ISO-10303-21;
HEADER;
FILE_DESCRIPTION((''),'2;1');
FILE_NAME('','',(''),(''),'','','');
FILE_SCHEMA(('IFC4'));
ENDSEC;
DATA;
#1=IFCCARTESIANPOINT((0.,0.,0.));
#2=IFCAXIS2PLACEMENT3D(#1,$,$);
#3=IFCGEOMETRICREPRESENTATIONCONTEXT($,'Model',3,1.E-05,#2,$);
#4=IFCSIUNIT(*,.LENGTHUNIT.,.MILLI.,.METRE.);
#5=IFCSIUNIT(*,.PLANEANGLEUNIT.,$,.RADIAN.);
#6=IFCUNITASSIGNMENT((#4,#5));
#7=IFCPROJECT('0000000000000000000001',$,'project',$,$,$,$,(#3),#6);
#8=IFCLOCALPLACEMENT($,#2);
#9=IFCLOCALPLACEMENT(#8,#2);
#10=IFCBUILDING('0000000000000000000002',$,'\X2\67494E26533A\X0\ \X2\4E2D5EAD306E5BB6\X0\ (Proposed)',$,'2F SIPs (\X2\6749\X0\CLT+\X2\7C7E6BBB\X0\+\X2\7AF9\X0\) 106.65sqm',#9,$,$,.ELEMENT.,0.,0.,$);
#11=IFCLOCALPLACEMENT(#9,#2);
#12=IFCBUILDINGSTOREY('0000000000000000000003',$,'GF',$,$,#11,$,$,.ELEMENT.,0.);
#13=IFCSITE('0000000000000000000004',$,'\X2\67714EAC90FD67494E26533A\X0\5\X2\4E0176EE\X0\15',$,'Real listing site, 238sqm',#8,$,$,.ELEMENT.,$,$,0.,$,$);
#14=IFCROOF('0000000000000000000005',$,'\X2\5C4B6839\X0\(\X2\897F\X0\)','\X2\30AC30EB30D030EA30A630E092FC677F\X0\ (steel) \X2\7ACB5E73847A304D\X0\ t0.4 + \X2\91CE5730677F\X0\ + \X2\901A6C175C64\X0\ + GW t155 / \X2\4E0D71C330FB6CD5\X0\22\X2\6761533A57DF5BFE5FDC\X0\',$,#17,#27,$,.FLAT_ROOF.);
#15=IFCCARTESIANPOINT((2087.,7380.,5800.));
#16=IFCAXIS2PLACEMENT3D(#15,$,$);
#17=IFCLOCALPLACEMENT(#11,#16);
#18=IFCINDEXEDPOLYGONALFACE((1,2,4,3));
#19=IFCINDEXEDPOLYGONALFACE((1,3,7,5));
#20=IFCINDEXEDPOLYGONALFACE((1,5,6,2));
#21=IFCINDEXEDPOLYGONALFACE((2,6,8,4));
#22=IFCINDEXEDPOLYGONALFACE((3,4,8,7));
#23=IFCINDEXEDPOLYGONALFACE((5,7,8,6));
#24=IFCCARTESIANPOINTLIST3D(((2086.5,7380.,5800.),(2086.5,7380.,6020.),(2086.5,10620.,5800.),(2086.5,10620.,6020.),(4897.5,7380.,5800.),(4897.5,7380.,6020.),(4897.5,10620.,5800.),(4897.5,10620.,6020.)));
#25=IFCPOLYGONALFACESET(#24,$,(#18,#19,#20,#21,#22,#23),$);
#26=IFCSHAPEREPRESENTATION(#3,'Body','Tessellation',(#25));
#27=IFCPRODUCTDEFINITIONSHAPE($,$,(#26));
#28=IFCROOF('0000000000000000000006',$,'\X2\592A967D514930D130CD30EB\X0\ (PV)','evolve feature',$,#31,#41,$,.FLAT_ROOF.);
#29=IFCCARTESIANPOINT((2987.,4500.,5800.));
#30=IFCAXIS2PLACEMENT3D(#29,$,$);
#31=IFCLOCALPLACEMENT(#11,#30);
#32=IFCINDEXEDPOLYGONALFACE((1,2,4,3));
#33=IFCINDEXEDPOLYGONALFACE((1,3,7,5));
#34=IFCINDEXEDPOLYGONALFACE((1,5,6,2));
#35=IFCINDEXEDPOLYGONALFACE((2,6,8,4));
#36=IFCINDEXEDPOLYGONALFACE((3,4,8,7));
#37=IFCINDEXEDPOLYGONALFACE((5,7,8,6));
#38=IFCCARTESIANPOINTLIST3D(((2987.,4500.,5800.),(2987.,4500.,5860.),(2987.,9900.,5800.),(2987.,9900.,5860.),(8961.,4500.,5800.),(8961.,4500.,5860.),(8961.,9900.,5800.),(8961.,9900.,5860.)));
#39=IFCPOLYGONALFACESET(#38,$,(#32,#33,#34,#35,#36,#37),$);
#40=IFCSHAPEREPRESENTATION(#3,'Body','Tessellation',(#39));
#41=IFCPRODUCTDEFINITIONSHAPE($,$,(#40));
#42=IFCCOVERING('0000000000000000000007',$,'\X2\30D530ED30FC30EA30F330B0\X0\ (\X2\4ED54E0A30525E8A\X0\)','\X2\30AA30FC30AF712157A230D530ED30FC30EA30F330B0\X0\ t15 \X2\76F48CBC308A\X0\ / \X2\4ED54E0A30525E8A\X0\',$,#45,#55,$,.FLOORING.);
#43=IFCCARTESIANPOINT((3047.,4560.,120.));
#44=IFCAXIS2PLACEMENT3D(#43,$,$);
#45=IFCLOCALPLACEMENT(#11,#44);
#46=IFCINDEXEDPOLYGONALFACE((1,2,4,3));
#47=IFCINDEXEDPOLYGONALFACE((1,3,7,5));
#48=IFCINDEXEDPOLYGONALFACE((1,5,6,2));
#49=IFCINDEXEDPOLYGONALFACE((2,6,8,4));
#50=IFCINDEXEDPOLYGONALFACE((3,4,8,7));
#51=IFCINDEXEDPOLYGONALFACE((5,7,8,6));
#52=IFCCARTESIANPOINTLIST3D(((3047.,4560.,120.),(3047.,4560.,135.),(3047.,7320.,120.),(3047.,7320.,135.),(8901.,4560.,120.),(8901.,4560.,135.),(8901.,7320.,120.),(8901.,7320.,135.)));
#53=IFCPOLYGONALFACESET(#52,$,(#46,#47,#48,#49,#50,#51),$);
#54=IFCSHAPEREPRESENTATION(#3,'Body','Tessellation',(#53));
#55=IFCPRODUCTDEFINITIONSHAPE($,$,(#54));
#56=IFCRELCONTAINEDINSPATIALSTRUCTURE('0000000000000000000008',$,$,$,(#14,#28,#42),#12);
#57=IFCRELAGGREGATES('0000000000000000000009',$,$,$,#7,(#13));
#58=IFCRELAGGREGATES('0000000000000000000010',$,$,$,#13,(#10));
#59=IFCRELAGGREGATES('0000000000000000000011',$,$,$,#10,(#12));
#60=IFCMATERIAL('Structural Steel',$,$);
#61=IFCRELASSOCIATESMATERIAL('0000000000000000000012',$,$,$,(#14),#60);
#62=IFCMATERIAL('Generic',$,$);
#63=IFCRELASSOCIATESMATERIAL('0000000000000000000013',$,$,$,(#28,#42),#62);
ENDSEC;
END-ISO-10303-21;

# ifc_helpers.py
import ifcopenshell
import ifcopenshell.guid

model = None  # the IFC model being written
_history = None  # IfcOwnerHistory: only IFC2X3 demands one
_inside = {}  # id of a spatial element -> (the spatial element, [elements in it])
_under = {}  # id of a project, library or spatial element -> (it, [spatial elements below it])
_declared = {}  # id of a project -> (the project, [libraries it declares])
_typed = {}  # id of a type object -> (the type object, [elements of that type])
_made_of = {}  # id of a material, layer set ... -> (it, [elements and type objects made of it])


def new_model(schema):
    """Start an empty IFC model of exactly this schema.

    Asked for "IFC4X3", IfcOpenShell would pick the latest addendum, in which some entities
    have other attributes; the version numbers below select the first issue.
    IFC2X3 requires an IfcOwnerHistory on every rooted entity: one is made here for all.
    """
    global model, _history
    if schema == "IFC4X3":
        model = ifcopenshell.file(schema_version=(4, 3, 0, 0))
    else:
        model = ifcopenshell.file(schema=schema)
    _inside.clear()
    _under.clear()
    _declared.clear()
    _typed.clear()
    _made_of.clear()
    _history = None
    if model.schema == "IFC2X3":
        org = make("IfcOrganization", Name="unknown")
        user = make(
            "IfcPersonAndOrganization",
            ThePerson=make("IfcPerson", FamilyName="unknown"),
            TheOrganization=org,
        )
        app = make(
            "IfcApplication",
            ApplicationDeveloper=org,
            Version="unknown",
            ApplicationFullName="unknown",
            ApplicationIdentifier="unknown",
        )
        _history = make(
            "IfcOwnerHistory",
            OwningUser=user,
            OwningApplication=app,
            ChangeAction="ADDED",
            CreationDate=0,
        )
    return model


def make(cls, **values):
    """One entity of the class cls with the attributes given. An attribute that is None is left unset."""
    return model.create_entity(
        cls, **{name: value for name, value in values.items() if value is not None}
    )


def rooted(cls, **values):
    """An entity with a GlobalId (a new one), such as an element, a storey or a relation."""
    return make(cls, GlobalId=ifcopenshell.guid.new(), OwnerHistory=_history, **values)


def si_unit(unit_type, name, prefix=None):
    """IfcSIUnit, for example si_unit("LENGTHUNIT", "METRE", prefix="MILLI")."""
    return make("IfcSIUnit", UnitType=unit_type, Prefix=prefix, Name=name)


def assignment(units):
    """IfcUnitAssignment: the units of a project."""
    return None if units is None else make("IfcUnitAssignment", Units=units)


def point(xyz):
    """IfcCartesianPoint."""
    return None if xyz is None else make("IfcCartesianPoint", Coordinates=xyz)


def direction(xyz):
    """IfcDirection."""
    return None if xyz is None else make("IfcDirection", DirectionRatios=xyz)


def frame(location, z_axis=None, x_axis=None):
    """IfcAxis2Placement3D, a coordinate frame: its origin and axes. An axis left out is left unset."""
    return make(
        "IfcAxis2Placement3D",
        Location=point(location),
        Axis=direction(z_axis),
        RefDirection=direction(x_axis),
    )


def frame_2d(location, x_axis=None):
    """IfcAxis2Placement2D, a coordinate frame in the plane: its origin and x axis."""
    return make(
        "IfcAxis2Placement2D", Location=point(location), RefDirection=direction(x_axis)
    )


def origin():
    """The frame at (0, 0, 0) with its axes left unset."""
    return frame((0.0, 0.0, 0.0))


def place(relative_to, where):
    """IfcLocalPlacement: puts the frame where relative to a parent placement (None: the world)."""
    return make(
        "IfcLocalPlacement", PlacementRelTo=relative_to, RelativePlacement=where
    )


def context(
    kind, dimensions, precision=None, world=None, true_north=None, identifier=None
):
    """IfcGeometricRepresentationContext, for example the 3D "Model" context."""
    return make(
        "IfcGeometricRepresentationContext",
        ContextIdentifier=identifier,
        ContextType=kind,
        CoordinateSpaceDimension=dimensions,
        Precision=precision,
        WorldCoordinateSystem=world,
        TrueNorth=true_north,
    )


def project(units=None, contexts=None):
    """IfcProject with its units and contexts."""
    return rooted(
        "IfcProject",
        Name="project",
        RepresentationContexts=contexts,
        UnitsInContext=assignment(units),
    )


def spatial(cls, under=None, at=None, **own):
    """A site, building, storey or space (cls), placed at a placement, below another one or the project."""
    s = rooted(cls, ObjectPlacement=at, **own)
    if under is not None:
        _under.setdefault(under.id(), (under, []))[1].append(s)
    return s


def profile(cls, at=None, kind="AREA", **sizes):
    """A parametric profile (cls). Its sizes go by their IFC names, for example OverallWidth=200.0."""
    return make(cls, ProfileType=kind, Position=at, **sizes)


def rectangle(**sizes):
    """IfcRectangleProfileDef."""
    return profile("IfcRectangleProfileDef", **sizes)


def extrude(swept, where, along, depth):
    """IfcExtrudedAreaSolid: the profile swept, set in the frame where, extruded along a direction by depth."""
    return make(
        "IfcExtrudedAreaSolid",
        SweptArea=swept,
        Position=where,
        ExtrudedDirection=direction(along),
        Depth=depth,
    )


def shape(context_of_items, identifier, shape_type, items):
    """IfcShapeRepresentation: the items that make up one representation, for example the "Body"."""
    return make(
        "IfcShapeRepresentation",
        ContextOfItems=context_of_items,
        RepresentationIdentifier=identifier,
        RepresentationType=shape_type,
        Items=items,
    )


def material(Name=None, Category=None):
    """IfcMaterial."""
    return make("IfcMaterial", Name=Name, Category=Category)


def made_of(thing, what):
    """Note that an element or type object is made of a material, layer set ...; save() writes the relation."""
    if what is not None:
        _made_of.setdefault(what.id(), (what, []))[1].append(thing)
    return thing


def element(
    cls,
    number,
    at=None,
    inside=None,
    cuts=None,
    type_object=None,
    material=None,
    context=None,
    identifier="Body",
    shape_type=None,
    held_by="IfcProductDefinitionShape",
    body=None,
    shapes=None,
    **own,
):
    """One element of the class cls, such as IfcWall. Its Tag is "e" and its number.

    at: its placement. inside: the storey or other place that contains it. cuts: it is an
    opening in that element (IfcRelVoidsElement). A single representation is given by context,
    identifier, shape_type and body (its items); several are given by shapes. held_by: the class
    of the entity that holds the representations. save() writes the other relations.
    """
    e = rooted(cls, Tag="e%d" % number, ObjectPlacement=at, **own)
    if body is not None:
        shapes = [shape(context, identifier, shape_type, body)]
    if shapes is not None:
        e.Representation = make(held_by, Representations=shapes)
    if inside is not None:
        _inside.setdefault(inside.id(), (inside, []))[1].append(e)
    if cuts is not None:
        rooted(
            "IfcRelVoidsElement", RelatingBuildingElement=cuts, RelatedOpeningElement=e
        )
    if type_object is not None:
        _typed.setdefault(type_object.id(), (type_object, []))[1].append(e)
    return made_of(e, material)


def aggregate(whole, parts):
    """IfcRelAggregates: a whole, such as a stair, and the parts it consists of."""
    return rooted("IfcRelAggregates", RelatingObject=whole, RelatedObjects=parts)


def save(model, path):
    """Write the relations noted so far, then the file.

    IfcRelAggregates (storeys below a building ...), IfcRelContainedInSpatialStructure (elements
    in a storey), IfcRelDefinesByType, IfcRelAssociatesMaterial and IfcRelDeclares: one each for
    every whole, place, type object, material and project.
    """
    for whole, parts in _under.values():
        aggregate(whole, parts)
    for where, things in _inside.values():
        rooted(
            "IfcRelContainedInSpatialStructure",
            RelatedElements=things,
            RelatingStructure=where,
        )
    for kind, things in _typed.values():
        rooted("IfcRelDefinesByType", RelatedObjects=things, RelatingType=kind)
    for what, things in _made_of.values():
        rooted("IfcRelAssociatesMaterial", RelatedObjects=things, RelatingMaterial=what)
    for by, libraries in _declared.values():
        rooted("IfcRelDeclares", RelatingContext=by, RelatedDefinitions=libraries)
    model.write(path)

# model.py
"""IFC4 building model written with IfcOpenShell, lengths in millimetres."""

from ifc_helpers import new_model, si_unit, frame, frame_2d, origin, place, context, project, spatial, rectangle, extrude, material, element, save


model = new_model("IFC4")

# Units and contexts
model_context = context("Model", 3, precision=1e-05, world=origin())
ifc_project = project(units=[si_unit("LENGTHUNIT", "METRE", prefix="MILLI"), si_unit("PLANEANGLEUNIT", "RADIAN")], contexts=[model_context])

# Site, building, storey
site_placement = place(None, origin())
site = spatial("IfcSite", under=ifc_project, at=site_placement, Name="東京都杉並区5丁目15", ObjectType="Real listing site, 238sqm", CompositionType="ELEMENT", RefElevation=0.0)
building_placement = place(site_placement, origin())
building = spatial("IfcBuilding", under=site, at=building_placement, Name="杉並区 中庭の家 (Proposed)", ObjectType="2F SIPs (杉CLT+籾殻+竹) 106.65sqm", CompositionType="ELEMENT", ElevationOfRefHeight=0.0, ElevationOfTerrain=0.0)
storey_placement = place(building_placement, origin())
storey = spatial("IfcBuildingStorey", under=building, at=storey_placement, Name="GF", CompositionType="ELEMENT", Elevation=0.0)

# Shared definitions
ifc_material_1 = material(Name="Generic")

# Roofs
ifc_material_2 = material(Name="Structural Steel")
roof_1_placement = place(storey_placement, frame((2087.0, 7380.0, 5800.0)))
element("IfcRoof", 1, at=roof_1_placement, inside=storey, material=ifc_material_2, Name="屋根(西)", Description="ガルバリウム鋼板 (steel) 立平葺き t0.4 + 野地板 + 通気層 + GW t155 / 不燃・法22条区域対応", PredefinedType="FLAT_ROOF", context=model_context, shape_type="SweptSolid", body=[
    extrude(rectangle(XDim=2811.0, YDim=3240.0, at=frame_2d((1405.0, 1620.0))), frame((2087.0, 7380.0, 5800.0)), (0.0, 0.0, 1.0), 220.0),
])
roof_2_placement = place(storey_placement, frame((2987.0, 4500.0, 5800.0)))
element("IfcRoof", 2, at=roof_2_placement, inside=storey, material=ifc_material_1, Name="太陽光パネル (PV)", Description="evolve feature", PredefinedType="FLAT_ROOF", context=model_context, shape_type="SweptSolid", body=[
    extrude(rectangle(XDim=5974.0, YDim=5400.0, at=frame_2d((2987.0, 2700.0))), frame((2987.0, 4500.0, 5800.0)), (0.0, 0.0, 1.0), 60.0),
])

# Covering
covering_placement = place(storey_placement, frame((3047.0, 4560.0, 120.0)))
element("IfcCovering", 3, at=covering_placement, inside=storey, material=ifc_material_1, Name="フローリング (仕上げ床)", Description="オーク無垢フローリング t15 直貼り / 仕上げ床", PredefinedType="FLOORING", context=model_context, shape_type="SweptSolid", body=[
    extrude(rectangle(XDim=5854.0, YDim=2760.0, at=frame_2d((2927.0, 1380.0))), frame((3047.0, 4560.0, 120.0)), (0.0, 0.0, 1.0), 15.0),
])

save(model, "model.ifc")
